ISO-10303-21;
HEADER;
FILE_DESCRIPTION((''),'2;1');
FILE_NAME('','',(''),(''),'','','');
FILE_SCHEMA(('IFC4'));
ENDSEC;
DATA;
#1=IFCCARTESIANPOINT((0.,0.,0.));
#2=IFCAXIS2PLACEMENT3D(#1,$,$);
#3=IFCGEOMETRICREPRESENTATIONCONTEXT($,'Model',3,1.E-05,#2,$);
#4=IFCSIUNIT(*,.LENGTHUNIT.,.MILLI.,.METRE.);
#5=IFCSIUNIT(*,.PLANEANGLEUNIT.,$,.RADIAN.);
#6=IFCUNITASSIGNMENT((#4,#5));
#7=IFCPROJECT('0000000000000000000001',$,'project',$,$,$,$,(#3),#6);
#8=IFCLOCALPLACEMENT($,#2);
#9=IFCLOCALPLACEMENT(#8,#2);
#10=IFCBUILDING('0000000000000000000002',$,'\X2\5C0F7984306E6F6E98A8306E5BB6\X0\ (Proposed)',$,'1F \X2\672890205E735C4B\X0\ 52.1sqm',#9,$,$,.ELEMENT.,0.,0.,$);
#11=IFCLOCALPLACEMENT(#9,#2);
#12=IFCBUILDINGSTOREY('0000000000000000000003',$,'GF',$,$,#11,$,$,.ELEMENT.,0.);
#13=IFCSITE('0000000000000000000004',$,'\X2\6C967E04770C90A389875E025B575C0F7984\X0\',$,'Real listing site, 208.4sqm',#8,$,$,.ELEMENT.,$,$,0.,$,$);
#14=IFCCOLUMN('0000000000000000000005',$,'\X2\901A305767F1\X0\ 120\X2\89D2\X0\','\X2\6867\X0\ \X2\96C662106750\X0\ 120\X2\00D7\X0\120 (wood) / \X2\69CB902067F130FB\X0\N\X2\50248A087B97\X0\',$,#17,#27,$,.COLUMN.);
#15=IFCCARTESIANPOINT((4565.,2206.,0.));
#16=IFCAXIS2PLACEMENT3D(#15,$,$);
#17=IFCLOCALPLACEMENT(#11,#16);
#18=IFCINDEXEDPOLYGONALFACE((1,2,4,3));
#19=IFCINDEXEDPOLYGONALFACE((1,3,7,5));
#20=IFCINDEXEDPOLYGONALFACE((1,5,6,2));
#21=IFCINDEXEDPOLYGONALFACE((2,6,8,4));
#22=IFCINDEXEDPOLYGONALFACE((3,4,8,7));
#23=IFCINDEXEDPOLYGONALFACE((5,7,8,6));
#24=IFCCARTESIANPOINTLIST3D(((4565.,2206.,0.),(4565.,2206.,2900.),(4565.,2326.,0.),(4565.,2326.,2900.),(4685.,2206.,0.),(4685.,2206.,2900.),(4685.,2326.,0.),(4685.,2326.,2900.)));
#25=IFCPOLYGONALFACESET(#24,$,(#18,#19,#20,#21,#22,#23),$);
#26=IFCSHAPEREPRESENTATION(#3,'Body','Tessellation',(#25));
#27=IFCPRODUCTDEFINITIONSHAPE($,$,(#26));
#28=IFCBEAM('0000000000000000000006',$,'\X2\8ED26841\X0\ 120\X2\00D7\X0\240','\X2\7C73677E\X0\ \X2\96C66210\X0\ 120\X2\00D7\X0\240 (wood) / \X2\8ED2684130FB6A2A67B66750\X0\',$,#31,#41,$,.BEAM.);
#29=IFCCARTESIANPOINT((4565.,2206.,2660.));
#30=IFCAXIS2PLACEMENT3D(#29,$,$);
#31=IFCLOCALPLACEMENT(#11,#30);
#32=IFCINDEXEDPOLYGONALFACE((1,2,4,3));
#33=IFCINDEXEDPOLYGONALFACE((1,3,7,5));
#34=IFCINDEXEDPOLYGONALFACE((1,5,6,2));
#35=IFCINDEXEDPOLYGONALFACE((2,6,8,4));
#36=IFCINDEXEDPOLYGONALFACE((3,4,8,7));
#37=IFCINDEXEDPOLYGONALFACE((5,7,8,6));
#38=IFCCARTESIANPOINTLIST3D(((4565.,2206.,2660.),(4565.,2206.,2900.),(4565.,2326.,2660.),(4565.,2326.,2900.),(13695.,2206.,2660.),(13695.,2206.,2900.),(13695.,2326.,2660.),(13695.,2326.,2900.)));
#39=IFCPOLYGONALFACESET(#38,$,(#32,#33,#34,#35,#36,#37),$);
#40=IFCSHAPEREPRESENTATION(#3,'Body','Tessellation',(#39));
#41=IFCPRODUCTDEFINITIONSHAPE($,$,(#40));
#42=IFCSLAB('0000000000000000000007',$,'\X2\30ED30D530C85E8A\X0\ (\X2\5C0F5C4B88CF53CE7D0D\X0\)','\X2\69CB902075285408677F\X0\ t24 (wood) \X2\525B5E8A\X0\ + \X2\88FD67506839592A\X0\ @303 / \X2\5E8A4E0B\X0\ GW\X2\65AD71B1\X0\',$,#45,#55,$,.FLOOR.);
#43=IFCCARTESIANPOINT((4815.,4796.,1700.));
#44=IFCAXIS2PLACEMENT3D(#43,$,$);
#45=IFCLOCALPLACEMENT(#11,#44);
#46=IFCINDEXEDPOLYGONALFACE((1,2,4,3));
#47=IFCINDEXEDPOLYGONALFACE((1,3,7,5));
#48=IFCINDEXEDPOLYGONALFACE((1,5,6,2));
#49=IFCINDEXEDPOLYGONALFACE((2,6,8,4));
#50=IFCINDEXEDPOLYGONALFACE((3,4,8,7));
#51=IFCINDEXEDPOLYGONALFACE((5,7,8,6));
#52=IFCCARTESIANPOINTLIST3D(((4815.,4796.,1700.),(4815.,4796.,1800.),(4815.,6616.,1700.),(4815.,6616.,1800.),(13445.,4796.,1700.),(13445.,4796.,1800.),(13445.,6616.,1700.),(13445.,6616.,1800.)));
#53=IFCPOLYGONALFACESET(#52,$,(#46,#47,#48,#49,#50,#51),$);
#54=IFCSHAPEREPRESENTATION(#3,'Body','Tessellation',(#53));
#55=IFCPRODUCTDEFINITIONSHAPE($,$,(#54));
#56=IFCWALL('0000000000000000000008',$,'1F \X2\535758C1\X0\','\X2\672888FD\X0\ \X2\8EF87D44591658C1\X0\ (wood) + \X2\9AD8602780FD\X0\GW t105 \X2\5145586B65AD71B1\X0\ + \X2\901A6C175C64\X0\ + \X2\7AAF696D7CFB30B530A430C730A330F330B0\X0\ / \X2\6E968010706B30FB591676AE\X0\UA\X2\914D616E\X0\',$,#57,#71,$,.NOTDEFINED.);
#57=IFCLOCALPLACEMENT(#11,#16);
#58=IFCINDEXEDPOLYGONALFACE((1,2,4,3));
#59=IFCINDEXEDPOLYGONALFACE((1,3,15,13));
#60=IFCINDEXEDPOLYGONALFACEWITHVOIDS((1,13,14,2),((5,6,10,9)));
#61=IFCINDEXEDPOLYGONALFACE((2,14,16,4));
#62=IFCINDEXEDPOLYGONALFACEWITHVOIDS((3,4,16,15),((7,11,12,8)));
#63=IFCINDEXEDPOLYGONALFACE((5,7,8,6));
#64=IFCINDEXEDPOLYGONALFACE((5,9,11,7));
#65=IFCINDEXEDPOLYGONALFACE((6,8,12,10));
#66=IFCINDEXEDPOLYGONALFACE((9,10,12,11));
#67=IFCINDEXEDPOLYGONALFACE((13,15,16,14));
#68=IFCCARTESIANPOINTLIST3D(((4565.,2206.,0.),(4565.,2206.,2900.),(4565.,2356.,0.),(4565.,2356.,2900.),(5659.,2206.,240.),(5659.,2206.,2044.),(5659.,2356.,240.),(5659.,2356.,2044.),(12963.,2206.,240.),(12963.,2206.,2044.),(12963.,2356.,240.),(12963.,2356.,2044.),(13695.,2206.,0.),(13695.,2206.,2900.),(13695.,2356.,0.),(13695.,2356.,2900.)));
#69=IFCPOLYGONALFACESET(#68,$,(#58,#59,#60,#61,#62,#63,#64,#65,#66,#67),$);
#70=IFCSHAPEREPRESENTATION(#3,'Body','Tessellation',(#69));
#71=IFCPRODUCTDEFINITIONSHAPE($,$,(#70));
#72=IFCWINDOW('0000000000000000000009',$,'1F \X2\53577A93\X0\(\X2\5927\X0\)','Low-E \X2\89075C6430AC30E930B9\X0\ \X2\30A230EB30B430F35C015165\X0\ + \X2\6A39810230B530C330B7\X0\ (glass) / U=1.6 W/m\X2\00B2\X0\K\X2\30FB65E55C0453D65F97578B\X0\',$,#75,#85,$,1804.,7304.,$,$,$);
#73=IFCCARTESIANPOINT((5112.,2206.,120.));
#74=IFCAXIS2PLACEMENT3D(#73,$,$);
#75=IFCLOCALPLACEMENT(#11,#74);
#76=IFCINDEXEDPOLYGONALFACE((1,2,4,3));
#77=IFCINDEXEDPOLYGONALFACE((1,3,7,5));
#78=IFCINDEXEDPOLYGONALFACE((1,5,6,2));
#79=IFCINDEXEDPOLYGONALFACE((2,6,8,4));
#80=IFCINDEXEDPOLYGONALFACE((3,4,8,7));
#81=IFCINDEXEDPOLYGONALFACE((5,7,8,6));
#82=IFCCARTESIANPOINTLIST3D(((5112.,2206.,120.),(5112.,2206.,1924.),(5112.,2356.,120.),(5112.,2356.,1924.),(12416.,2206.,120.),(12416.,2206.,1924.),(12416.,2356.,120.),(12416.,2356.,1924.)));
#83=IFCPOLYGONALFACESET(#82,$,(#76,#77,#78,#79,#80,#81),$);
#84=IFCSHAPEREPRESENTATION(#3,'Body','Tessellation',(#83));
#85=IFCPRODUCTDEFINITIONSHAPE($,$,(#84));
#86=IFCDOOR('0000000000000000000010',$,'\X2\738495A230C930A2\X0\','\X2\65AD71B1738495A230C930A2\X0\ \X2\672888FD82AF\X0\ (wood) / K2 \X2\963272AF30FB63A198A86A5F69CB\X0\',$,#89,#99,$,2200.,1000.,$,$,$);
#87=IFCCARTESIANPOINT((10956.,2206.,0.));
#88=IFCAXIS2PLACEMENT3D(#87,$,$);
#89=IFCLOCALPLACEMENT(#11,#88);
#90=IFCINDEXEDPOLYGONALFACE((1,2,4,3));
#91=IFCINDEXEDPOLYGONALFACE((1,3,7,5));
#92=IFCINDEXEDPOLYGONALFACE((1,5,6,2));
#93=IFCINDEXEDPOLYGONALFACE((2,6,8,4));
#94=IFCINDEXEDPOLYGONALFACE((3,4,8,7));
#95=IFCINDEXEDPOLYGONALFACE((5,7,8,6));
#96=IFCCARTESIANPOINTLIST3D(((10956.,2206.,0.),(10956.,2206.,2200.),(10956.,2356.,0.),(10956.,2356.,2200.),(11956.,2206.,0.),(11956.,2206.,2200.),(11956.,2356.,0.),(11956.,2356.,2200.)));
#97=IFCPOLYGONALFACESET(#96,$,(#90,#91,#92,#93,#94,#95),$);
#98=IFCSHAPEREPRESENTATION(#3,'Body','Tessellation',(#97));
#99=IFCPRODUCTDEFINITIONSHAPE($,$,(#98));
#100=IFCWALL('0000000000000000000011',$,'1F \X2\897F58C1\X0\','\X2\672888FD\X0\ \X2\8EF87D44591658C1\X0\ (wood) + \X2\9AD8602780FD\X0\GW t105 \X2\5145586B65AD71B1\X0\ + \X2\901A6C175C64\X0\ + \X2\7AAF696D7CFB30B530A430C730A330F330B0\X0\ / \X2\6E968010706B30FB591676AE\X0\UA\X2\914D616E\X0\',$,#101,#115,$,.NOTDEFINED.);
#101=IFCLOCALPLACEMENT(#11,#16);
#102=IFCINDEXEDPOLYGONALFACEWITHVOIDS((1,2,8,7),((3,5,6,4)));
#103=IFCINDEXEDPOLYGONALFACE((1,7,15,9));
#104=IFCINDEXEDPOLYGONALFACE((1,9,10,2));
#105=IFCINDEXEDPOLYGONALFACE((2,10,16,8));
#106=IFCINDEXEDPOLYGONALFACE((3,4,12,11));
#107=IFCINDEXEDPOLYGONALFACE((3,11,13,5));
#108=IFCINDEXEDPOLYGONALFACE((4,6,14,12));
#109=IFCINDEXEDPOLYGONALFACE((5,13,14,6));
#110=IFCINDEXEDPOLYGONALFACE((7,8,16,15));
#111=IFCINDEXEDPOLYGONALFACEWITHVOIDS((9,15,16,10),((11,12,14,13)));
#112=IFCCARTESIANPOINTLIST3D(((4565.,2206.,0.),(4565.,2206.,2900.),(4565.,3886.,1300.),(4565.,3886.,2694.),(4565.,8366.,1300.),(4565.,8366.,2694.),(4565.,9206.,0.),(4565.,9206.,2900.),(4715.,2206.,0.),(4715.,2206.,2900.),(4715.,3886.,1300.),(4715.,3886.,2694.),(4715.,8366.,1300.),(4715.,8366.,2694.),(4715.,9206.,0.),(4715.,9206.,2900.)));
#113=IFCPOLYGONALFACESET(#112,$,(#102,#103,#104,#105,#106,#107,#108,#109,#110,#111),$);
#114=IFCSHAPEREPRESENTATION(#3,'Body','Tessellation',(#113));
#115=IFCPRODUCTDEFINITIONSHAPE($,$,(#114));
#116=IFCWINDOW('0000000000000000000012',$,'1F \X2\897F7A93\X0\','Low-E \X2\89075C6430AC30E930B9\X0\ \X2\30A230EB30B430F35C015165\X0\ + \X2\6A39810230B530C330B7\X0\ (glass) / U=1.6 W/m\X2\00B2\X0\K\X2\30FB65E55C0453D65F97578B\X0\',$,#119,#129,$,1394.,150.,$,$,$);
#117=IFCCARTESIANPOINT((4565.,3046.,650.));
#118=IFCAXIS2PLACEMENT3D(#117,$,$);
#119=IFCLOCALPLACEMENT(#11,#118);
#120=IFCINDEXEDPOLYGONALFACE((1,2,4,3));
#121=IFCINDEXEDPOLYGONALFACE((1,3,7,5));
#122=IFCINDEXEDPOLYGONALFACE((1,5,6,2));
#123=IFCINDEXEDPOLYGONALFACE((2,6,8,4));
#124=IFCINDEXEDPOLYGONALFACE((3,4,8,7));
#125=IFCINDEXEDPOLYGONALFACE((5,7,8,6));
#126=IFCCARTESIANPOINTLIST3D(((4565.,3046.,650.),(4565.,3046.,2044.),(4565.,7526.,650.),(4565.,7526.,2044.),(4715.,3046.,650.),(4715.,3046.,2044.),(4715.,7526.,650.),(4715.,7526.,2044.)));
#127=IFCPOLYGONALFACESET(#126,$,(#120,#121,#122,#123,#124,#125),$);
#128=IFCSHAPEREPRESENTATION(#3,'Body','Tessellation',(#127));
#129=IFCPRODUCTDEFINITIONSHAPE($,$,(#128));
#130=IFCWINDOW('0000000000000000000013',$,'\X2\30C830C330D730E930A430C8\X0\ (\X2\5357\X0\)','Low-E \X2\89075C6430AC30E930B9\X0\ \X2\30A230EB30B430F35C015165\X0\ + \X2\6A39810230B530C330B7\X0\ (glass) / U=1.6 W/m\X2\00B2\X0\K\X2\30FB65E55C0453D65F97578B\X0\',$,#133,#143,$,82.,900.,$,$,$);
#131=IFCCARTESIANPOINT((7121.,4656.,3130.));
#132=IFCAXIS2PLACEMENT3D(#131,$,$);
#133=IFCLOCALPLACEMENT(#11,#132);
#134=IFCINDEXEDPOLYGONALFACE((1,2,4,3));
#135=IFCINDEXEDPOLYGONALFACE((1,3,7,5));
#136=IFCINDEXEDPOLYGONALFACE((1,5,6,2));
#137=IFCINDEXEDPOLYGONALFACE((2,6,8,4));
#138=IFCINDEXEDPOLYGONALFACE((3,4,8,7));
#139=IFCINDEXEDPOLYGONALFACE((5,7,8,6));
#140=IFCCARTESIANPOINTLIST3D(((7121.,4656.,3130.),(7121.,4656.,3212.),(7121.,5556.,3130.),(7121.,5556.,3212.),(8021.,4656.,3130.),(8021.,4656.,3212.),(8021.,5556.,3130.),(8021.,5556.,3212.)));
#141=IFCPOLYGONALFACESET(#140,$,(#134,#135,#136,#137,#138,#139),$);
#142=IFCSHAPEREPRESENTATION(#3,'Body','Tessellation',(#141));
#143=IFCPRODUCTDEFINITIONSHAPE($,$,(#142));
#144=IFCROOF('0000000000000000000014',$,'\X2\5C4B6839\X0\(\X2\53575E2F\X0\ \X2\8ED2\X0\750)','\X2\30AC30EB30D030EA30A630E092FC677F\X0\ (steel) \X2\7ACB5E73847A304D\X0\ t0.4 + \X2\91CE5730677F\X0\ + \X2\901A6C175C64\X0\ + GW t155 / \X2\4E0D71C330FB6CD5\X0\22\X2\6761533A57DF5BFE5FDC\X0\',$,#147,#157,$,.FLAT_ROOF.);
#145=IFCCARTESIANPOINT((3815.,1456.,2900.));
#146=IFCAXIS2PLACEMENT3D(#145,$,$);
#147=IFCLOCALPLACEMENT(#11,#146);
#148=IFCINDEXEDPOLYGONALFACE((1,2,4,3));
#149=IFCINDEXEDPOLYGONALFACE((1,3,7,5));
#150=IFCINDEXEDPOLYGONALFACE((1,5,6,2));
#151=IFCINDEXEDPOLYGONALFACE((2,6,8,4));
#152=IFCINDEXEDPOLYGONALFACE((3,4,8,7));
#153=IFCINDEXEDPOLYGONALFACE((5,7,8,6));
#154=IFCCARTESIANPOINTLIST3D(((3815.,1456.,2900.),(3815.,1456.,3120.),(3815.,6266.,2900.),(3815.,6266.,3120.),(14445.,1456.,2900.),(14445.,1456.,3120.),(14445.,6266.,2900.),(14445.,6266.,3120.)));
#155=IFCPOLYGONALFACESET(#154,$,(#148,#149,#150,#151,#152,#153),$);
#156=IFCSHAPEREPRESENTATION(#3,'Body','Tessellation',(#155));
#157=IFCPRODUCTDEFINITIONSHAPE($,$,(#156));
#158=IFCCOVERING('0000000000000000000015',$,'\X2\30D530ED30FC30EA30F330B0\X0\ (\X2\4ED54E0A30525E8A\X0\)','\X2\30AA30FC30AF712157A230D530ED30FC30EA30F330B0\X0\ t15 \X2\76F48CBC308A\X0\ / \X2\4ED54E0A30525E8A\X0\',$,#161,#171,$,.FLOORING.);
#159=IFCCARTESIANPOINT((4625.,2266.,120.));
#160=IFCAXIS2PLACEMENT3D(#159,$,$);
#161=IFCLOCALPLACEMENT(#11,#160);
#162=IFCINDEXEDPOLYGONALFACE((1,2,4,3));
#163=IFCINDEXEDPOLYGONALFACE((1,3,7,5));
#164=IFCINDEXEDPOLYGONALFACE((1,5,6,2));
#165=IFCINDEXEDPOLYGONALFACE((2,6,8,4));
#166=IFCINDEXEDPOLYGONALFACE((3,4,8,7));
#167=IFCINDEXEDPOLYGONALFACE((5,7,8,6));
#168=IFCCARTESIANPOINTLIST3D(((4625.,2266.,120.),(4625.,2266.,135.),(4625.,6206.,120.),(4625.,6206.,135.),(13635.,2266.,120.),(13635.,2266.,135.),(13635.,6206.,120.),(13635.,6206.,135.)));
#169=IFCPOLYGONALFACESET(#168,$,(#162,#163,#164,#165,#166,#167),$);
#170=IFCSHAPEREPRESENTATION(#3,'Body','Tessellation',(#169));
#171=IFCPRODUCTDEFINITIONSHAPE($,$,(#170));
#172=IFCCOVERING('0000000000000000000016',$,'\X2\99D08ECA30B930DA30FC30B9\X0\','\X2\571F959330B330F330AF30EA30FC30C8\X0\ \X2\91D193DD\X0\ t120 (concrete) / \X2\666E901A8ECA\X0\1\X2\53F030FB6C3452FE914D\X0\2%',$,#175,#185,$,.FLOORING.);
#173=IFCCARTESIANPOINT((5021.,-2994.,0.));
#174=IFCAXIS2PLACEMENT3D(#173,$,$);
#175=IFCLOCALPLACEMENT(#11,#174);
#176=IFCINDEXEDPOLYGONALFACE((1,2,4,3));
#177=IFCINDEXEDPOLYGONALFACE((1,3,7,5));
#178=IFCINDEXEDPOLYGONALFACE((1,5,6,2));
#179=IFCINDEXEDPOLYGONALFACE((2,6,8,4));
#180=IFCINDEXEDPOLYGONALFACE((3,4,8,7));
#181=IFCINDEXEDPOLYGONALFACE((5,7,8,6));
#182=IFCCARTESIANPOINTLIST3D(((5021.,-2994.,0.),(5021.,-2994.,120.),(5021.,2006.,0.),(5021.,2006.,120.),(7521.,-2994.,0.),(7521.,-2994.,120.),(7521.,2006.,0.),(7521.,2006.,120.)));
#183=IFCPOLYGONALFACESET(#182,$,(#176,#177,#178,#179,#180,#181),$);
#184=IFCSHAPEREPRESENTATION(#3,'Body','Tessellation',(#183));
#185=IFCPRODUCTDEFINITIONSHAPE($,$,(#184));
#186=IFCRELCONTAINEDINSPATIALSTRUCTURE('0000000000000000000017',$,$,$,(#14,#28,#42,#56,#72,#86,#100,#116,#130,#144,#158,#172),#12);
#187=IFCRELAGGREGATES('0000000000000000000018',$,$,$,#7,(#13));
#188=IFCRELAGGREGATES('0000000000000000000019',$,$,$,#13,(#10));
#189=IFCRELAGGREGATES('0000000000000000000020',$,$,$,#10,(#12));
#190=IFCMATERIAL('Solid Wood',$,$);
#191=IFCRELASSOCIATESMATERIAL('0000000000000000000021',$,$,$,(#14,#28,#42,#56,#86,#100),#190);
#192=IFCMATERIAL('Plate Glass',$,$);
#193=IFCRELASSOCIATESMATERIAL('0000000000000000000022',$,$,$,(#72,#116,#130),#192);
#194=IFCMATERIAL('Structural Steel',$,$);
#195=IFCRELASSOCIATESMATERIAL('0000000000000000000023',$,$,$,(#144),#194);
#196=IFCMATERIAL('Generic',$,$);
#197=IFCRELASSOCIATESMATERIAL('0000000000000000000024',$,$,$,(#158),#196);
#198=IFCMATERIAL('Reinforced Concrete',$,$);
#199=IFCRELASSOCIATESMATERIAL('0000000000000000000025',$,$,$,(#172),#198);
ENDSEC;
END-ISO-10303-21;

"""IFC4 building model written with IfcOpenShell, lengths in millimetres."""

from ifc_helpers import new_model, si_unit, frame, frame_2d, origin, place, context, project, spatial, rectangle, extrude, material, element, fill, save


model = new_model("IFC4")

# Units and contexts
model_context = context("Model", 3, precision=1e-05, world=origin())
ifc_project = project(units=[si_unit("LENGTHUNIT", "METRE", prefix="MILLI"), si_unit("PLANEANGLEUNIT", "RADIAN")], contexts=[model_context])

# Site, building, storey
site_placement = place(None, origin())
site = spatial("IfcSite", under=ifc_project, at=site_placement, Name="沖縄県那覇市字小禄", ObjectType="Real listing site, 208.4sqm", CompositionType="ELEMENT", RefElevation=0.0)
building_placement = place(site_placement, origin())
building = spatial("IfcBuilding", under=site, at=building_placement, Name="小禄の潮風の家 (Proposed)", ObjectType="1F 木造平屋 52.1sqm", CompositionType="ELEMENT", ElevationOfRefHeight=0.0, ElevationOfTerrain=0.0)
storey_placement = place(building_placement, origin())
storey = spatial("IfcBuildingStorey", under=building, at=storey_placement, Name="GF", CompositionType="ELEMENT", Elevation=0.0)

# Column
ifc_material_1 = material(Name="Solid Wood")
column_1_placement = place(storey_placement, frame((4565.0, 2206.0, 0.0)))
element("IfcColumn", 1, at=column_1_placement, inside=storey, material=ifc_material_1, Name="通し柱 120角", Description="桧 集成材 120×120 (wood) / 構造柱・N値計算", PredefinedType="COLUMN", context=model_context, shape_type="SweptSolid", body=[
    extrude(rectangle(XDim=120.0, YDim=120.0, at=frame_2d((60.0, 60.0))), frame((4565.0, 2206.0, 0.0)), (0.0, 0.0, 1.0), 2900.0),
])

# Beam
beam_1_placement = place(storey_placement, frame((4565.0, 2206.0, 2660.0)))
element("IfcBeam", 2, at=beam_1_placement, inside=storey, material=ifc_material_1, Name="軒桁 120×240", Description="米松 集成 120×240 (wood) / 軒桁・横架材", PredefinedType="BEAM", context=model_context, shape_type="SweptSolid", body=[
    extrude(rectangle(XDim=9130.0, YDim=120.0, at=frame_2d((4565.0, 60.0))), frame((4565.0, 2206.0, 2660.0)), (0.0, 0.0, 1.0), 240.0),
])

# Slab
ifc_material_2 = material(Name="Reinforced Concrete")
slab_1_placement = place(storey_placement, frame((4815.0, 4796.0, 1700.0)))
element("IfcSlab", 3, at=slab_1_placement, inside=storey, material=ifc_material_1, Name="ロフト床 (小屋裏収納)", Description="構造用合板 t24 (wood) 剛床 + 製材根太 @303 / 床下 GW断熱", PredefinedType="FLOOR", context=model_context, shape_type="SweptSolid", body=[
    extrude(rectangle(XDim=8630.0, YDim=1820.0, at=frame_2d((4315.0, 910.0))), frame((4815.0, 4796.0, 1700.0)), (0.0, 0.0, 1.0), 100.0),
])

# Wall, openings, window, door
wall_1_placement = place(storey_placement, frame((4565.0, 2206.0, 0.0)))
wall_1 = element("IfcWall", 4, at=wall_1_placement, inside=storey, material=ifc_material_1, Name="1F 南壁", Description="木製 軸組外壁 (wood) + 高性能GW t105 充填断熱 + 通気層 + 窯業系サイディング / 準耐火・外皮UA配慮", PredefinedType="NOTDEFINED", context=model_context, shape_type="SweptSolid", body=[
    extrude(rectangle(XDim=9130.0, YDim=150.0, at=frame_2d((4565.0, 75.0))), frame((4565.0, 2206.0, 0.0)), (0.0, 0.0, 1.0), 2900.0),
])
opening_1_placement = place(storey_placement, frame((5112.0, 2206.0, 120.0)))
opening_1 = element("IfcOpeningElement", 5, at=opening_1_placement, cuts=wall_1, PredefinedType="NOTDEFINED", context=model_context, shape_type="SweptSolid", body=[
    extrude(rectangle(XDim=7304.0, YDim=150.0, at=frame_2d((3652.0, 75.0))), frame((5112.0, 2206.0, 120.0)), (0.0, 0.0, 1.0), 1804.0),
])
opening_2_placement = place(storey_placement, frame((10956.0, 2206.0, 0.0)))
opening_2 = element("IfcOpeningElement", 6, at=opening_2_placement, cuts=wall_1, PredefinedType="NOTDEFINED", context=model_context, shape_type="SweptSolid", body=[
    extrude(rectangle(XDim=1000.0, YDim=150.0, at=frame_2d((500.0, 75.0))), frame((10956.0, 2206.0, 0.0)), (0.0, 0.0, 1.0), 2200.0),
])
ifc_material_3 = material(Name="Plate Glass")
window_1_placement = place(storey_placement, frame((5112.0, 2206.0, 120.0)))
window_1 = element("IfcWindow", 7, at=window_1_placement, inside=storey, material=ifc_material_3, Name="1F 南窓(大)", Description="Low-E 複層ガラス アルゴン封入 + 樹脂サッシ (glass) / U=1.6 W/m²K・日射取得型", OverallHeight=1804.0, OverallWidth=7304.0, context=model_context, shape_type="SweptSolid", body=[
    extrude(rectangle(XDim=7304.0, YDim=150.0, at=frame_2d((3652.0, 75.0))), frame((5112.0, 2206.0, 120.0)), (0.0, 0.0, 1.0), 1804.0),
])
fill(opening_1, window_1)
door_1_placement = place(storey_placement, frame((10956.0, 2206.0, 0.0)))
door_1 = element("IfcDoor", 8, at=door_1_placement, inside=storey, material=ifc_material_1, Name="玄関ドア", Description="断熱玄関ドア 木製芯 (wood) / K2 防犯・採風機構", OverallHeight=2200.0, OverallWidth=1000.0, context=model_context, shape_type="SweptSolid", body=[
    extrude(rectangle(XDim=1000.0, YDim=150.0, at=frame_2d((500.0, 75.0))), frame((10956.0, 2206.0, 0.0)), (0.0, 0.0, 1.0), 2200.0),
])
fill(opening_2, door_1)

# Wall, opening, window
wall_2_placement = place(storey_placement, frame((4565.0, 2206.0, 0.0)))
wall_2 = element("IfcWall", 9, at=wall_2_placement, inside=storey, material=ifc_material_1, Name="1F 西壁", Description="木製 軸組外壁 (wood) + 高性能GW t105 充填断熱 + 通気層 + 窯業系サイディング / 準耐火・外皮UA配慮", PredefinedType="NOTDEFINED", context=model_context, shape_type="SweptSolid", body=[
    extrude(rectangle(XDim=150.0, YDim=7000.0, at=frame_2d((75.0, 3500.0))), frame((4565.0, 2206.0, 0.0)), (0.0, 0.0, 1.0), 2900.0),
])
opening_3_placement = place(storey_placement, frame((4565.0, 3046.0, 650.0)))
opening_3 = element("IfcOpeningElement", 10, at=opening_3_placement, cuts=wall_2, PredefinedType="NOTDEFINED", context=model_context, shape_type="SweptSolid", body=[
    extrude(rectangle(XDim=150.0, YDim=4480.0, at=frame_2d((75.0, 2240.0))), frame((4565.0, 3046.0, 650.0)), (0.0, 0.0, 1.0), 1394.0),
])
window_2_placement = place(storey_placement, frame((4565.0, 3046.0, 650.0)))
window_2 = element("IfcWindow", 11, at=window_2_placement, inside=storey, material=ifc_material_3, Name="1F 西窓", Description="Low-E 複層ガラス アルゴン封入 + 樹脂サッシ (glass) / U=1.6 W/m²K・日射取得型", OverallHeight=1394.0, OverallWidth=150.0, context=model_context, shape_type="SweptSolid", body=[
    extrude(rectangle(XDim=150.0, YDim=4480.0, at=frame_2d((75.0, 2240.0))), frame((4565.0, 3046.0, 650.0)), (0.0, 0.0, 1.0), 1394.0),
])
fill(opening_3, window_2)

# Window
window_3_placement = place(storey_placement, frame((7121.0, 4656.0, 3130.0)))
element("IfcWindow", 12, at=window_3_placement, inside=storey, material=ifc_material_3, Name="トップライト (南)", Description="Low-E 複層ガラス アルゴン封入 + 樹脂サッシ (glass) / U=1.6 W/m²K・日射取得型", OverallHeight=82.0, OverallWidth=900.0, context=model_context, shape_type="SweptSolid", body=[
    extrude(rectangle(XDim=900.0, YDim=900.0, at=frame_2d((450.0, 450.0))), frame((7121.0, 4656.0, 3130.0)), (0.0, 0.0, 1.0), 82.0),
])

# Roof
ifc_material_4 = material(Name="Structural Steel")
roof_placement = place(storey_placement, frame((3815.0, 1456.0, 2900.0)))
element("IfcRoof", 13, at=roof_placement, inside=storey, material=ifc_material_4, Name="屋根(南帯 軒750)", Description="ガルバリウム鋼板 (steel) 立平葺き t0.4 + 野地板 + 通気層 + GW t155 / 不燃・法22条区域対応", PredefinedType="FLAT_ROOF", context=model_context, shape_type="SweptSolid", body=[
    extrude(rectangle(XDim=10630.0, YDim=4810.0, at=frame_2d((5315.0, 2405.0))), frame((3815.0, 1456.0, 2900.0)), (0.0, 0.0, 1.0), 220.0),
])

# Coverings
ifc_material_5 = material(Name="Generic")
covering_1_placement = place(storey_placement, frame((4625.0, 2266.0, 120.0)))
element("IfcCovering", 14, at=covering_1_placement, inside=storey, material=ifc_material_5, Name="フローリング (仕上げ床)", Description="オーク無垢フローリング t15 直貼り / 仕上げ床", PredefinedType="FLOORING", context=model_context, shape_type="SweptSolid", body=[
    extrude(rectangle(XDim=9010.0, YDim=3940.0, at=frame_2d((4505.0, 1970.0))), frame((4625.0, 2266.0, 120.0)), (0.0, 0.0, 1.0), 15.0),
])
covering_2_placement = place(storey_placement, frame((5021.0, -2994.0, 0.0)))
element("IfcCovering", 15, at=covering_2_placement, inside=storey, material=ifc_material_2, Name="駐車スペース", Description="土間コンクリート 金鏝 t120 (concrete) / 普通車1台・水勾配2%", PredefinedType="FLOORING", context=model_context, shape_type="SweptSolid", body=[
    extrude(rectangle(XDim=2500.0, YDim=5000.0, at=frame_2d((1250.0, 2500.0))), frame((5021.0, -2994.0, 0.0)), (0.0, 0.0, 1.0), 120.0),
])

save(model, "model.ifc")
